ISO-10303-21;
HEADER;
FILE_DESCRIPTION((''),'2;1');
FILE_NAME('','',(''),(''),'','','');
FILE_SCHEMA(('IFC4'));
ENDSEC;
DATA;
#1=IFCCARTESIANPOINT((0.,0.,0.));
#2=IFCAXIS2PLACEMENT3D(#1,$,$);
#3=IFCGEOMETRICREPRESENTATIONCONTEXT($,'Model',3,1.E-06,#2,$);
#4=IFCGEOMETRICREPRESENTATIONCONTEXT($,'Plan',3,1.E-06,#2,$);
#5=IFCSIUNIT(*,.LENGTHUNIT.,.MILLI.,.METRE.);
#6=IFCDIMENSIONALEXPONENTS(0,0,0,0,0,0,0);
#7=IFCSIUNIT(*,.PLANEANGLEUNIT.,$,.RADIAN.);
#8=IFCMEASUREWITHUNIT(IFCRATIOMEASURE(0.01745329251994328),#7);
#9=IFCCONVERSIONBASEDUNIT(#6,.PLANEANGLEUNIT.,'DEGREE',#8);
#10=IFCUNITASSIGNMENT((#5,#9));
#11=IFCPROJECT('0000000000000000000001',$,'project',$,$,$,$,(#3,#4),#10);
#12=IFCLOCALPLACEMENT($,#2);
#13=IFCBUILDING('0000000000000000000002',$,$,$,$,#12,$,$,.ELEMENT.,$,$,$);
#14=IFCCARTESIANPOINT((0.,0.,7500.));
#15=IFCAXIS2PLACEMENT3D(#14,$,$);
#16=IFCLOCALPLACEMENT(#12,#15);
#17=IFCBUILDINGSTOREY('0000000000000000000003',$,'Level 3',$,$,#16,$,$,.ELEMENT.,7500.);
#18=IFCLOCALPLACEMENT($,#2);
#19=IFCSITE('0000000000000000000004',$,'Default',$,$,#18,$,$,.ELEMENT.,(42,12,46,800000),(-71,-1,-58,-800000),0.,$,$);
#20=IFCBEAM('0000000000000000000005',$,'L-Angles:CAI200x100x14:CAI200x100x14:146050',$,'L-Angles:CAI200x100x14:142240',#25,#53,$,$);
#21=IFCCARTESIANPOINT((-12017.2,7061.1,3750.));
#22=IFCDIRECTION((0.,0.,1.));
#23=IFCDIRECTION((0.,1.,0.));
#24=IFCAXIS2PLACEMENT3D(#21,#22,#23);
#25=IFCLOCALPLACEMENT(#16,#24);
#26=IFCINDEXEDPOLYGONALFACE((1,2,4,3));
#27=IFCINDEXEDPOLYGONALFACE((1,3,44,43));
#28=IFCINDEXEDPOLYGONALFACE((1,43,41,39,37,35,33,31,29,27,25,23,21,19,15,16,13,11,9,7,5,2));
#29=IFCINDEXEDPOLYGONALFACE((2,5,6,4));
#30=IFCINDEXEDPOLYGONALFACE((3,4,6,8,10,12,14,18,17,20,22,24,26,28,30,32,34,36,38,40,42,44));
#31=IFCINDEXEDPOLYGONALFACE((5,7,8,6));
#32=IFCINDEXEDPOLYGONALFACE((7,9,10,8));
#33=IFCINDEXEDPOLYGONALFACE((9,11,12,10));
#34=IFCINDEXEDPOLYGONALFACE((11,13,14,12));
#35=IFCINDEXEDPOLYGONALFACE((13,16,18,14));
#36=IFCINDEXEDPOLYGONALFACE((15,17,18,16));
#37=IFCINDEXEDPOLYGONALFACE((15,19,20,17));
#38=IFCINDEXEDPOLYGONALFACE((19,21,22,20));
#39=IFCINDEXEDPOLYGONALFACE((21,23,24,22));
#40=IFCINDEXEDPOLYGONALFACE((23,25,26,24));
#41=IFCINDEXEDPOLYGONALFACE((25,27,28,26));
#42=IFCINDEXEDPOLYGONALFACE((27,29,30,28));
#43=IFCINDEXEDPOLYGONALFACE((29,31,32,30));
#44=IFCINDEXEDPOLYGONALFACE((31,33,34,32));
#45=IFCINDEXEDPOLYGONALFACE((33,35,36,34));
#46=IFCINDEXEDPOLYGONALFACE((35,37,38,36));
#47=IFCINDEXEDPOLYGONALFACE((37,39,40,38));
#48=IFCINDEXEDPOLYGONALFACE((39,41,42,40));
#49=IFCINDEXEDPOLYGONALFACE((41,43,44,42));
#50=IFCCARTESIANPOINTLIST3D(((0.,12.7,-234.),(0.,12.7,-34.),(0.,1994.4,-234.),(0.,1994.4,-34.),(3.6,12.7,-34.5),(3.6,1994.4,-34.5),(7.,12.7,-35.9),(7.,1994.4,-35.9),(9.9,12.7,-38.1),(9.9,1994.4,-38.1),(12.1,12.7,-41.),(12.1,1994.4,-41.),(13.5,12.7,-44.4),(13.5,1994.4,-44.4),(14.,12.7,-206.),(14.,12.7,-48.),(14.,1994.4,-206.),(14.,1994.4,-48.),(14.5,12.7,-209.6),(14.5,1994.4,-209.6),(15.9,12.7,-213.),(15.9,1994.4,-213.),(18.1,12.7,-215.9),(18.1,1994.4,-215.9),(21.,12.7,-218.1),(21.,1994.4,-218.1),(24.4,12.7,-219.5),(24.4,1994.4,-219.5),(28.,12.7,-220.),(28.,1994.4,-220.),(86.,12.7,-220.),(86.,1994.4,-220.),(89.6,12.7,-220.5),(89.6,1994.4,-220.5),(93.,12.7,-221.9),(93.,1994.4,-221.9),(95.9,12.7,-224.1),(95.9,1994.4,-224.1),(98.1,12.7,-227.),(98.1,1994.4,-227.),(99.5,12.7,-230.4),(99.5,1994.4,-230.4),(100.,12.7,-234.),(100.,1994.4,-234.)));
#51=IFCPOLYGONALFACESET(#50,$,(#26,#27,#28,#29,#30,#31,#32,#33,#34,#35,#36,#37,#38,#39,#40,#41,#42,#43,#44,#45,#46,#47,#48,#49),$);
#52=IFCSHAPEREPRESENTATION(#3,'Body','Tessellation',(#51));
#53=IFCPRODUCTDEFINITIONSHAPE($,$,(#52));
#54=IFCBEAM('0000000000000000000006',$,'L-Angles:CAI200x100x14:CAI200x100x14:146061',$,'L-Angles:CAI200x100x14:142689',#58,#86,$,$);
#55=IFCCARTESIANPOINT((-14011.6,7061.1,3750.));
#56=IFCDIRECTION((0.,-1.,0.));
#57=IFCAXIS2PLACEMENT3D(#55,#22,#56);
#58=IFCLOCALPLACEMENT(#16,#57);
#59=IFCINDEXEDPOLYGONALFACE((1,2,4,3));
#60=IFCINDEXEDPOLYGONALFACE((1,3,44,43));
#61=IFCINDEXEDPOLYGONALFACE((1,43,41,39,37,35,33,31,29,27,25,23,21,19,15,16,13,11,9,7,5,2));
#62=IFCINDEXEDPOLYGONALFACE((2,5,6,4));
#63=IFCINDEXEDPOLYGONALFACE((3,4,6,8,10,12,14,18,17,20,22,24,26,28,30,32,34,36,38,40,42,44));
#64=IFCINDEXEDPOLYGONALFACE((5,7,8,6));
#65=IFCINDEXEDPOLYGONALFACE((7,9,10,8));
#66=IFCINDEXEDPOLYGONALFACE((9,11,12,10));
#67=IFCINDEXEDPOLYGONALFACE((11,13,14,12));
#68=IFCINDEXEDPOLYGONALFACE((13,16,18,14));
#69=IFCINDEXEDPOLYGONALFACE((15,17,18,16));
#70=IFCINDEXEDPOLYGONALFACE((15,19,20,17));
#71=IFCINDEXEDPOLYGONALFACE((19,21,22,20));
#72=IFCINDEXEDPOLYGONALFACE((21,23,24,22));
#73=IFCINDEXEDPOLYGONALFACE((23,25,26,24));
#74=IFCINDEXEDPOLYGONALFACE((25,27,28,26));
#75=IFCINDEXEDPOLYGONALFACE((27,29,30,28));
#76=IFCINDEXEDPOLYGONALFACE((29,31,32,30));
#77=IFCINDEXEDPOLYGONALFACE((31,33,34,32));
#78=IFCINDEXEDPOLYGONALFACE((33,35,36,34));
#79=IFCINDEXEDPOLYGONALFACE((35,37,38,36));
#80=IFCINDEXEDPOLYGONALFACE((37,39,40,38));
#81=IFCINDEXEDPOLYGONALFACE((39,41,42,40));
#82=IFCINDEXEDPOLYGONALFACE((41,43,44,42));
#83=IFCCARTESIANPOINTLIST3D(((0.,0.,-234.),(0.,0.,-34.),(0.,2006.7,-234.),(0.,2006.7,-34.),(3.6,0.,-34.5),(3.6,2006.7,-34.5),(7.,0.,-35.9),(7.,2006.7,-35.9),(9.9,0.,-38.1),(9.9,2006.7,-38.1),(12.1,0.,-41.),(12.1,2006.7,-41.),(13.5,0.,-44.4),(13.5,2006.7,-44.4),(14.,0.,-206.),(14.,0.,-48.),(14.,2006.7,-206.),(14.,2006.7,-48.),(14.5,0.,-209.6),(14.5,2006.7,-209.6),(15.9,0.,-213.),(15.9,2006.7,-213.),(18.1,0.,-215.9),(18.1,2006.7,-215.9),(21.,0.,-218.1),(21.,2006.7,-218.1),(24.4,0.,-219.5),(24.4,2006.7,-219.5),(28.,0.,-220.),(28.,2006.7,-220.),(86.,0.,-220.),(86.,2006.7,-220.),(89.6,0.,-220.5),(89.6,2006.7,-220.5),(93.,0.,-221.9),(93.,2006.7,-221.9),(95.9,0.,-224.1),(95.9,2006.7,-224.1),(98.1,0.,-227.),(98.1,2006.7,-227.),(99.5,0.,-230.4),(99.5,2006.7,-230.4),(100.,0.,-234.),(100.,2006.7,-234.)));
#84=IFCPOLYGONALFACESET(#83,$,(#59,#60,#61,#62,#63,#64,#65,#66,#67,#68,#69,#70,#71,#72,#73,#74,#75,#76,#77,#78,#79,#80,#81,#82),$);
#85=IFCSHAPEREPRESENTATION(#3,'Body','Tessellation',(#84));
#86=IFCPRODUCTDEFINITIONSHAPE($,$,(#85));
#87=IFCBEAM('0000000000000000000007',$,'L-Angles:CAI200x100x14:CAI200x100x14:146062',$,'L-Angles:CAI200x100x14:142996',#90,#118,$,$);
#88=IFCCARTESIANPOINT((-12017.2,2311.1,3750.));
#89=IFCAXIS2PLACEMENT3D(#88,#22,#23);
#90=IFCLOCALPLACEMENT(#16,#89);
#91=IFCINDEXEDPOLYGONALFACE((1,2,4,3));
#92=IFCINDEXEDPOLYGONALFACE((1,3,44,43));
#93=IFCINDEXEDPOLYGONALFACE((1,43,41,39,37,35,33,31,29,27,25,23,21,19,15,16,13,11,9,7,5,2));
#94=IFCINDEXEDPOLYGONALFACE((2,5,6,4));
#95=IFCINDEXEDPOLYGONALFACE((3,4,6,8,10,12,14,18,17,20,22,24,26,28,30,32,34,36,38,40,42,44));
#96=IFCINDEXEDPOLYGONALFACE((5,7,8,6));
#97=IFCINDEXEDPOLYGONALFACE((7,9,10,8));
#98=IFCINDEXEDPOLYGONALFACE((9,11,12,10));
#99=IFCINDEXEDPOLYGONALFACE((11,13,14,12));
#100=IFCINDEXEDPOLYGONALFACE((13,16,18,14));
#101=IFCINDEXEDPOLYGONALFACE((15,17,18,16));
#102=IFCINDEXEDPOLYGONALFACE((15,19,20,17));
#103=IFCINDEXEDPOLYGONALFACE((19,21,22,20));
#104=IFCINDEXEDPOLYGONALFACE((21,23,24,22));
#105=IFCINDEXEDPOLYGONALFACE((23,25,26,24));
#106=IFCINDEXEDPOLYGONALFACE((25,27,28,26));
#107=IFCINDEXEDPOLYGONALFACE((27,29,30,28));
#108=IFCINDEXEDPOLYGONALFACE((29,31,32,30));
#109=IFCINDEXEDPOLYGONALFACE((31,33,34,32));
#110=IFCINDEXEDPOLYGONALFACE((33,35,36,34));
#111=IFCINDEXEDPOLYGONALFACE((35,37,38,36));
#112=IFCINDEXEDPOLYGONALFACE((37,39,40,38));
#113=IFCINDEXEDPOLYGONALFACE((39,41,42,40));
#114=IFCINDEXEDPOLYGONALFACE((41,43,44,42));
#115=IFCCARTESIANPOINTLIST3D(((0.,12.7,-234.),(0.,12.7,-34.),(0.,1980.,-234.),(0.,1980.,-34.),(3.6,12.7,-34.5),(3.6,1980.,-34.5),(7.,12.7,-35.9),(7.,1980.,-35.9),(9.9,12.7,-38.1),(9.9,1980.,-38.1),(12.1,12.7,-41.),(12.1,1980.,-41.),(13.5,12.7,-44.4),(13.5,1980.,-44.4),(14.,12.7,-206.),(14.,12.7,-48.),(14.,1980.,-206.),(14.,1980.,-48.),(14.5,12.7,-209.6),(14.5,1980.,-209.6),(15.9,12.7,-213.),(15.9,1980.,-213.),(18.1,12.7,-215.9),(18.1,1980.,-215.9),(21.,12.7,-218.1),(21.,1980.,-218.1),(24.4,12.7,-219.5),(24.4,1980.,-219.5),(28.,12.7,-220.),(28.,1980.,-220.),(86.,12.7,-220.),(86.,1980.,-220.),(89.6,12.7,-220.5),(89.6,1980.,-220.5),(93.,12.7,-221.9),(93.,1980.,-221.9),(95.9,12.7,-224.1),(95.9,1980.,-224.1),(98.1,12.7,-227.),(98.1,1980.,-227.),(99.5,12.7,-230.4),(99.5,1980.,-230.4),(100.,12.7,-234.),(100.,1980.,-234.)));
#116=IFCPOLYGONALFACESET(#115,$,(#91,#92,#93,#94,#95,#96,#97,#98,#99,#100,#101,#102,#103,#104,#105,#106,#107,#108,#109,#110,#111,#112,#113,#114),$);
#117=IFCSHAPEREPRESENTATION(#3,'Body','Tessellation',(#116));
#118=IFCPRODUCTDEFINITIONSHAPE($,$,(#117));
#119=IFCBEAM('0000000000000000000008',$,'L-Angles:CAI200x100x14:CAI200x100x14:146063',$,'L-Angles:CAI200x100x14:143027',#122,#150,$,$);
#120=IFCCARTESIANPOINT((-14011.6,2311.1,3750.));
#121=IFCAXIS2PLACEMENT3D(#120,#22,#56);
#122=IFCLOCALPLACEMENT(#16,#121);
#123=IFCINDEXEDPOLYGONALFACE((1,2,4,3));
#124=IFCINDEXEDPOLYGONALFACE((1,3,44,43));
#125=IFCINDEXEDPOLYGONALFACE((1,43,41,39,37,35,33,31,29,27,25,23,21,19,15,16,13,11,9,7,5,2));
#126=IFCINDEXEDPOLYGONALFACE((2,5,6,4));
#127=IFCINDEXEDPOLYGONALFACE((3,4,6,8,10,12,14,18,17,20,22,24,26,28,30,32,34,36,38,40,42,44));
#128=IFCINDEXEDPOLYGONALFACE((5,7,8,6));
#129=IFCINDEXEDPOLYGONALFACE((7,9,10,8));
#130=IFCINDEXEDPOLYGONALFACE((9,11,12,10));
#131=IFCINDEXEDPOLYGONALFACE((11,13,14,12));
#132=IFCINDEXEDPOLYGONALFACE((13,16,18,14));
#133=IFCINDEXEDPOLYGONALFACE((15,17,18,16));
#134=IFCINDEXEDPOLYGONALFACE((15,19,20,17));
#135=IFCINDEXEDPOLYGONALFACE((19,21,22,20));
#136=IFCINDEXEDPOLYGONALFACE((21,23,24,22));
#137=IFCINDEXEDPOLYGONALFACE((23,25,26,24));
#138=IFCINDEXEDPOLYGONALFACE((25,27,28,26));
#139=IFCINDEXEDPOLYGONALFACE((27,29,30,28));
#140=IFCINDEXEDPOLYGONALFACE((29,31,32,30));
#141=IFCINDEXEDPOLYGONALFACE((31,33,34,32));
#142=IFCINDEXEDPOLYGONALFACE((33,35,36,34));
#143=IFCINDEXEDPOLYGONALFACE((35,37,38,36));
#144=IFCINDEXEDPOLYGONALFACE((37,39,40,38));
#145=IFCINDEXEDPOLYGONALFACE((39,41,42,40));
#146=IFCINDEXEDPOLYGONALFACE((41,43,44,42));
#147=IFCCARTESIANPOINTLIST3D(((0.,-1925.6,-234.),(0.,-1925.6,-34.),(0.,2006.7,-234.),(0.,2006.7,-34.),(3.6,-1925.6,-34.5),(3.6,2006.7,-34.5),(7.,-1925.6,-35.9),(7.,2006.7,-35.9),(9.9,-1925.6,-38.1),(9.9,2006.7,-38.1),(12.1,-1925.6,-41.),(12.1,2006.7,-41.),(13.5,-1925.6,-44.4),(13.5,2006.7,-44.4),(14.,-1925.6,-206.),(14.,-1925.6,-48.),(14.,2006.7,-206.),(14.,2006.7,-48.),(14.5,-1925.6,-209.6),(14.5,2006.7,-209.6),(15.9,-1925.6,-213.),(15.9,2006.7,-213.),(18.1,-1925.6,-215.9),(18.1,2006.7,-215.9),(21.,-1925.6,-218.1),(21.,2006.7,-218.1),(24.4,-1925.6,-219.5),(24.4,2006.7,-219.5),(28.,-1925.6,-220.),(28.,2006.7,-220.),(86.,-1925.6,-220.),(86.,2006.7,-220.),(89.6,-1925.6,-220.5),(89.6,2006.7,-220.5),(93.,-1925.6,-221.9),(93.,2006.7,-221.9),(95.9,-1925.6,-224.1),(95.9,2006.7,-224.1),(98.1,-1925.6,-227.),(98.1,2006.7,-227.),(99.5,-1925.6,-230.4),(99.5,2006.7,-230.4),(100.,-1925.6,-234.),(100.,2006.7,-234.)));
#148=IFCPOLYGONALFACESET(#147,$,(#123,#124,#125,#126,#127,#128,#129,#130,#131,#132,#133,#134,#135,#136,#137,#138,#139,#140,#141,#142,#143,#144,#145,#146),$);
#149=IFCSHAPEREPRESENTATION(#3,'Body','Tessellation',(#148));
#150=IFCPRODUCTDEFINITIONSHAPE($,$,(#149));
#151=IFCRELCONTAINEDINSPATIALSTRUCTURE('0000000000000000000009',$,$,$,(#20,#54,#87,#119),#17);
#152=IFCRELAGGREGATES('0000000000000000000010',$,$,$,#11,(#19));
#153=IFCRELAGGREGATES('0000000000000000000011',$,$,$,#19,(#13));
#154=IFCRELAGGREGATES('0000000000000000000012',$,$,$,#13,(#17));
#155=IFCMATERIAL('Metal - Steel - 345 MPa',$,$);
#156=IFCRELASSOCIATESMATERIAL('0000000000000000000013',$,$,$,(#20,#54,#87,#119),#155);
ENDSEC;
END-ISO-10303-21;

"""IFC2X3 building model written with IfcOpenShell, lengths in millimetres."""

from ifc_helpers import new_model, entity, si_unit, converted_unit, frame, frame_2d, origin, place, context, project, spatial, polyline, circle_curve, parameter, trimmed, segment, composite_curve, outline, extrude, material, element, save


model = new_model("IFC2X3")

# Units and contexts
model_context = context("Model", 3, precision=1e-06, world=origin())
plan_context = context("Plan", 3, precision=1e-06, world=origin())
ifc_project = project(units=[si_unit("LENGTHUNIT", "METRE", prefix="MILLI"), converted_unit("PLANEANGLEUNIT", "DEGREE", entity("IfcRatioMeasure", 0.01745329251994328), si_unit("PLANEANGLEUNIT", "RADIAN"), dimensions=[0, 0, 0, 0, 0, 0, 0])], contexts=[model_context, plan_context])

# Site, building, storey
site_placement = place(None, origin())
site = spatial("IfcSite", under=ifc_project, at=site_placement, Name="Default", CompositionType="ELEMENT", RefLatitude=(42, 12, 46, 800000), RefLongitude=(-71, -1, -58, -800000), RefElevation=0.0)
building_placement = place(None, origin())
building = spatial("IfcBuilding", under=site, at=building_placement, CompositionType="ELEMENT")
storey_placement = place(building_placement, frame((0.0, 0.0, 7500.0)))
storey = spatial("IfcBuildingStorey", under=building, at=storey_placement, Name="Level 3", CompositionType="ELEMENT", Elevation=7500.0)

# Shared definitions
ifc_material_1 = material(Name="Metal - Steel - 345 MPa")

# Beams
beam_1_placement = place(storey_placement, frame((-12017.2, 7061.1, 3750.0), z_axis=(0.0, 0.0, 1.0), x_axis=(0.0, 1.0, 0.0)))
element("IfcBeam", 1, at=beam_1_placement, inside=storey, material=ifc_material_1, Name="L-Angles:CAI200x100x14:CAI200x100x14:146050", ObjectType="L-Angles:CAI200x100x14:142240", context=model_context, shape_type="SweptSolid", body=[
    extrude(outline(composite_curve([segment(polyline([(-34.6, -63.1), (65.4, -63.1)]), True, "CONTINUOUS"), segment(trimmed(circle_curve(frame_2d((51.4, -63.1), x_axis=(1.0, 0.0)), 14.0), [parameter(0.0)], [parameter(90.0)], True, "PARAMETER"), True, "CONTINUOUS"), segment(polyline([(51.4, -49.1), (-6.6, -49.1)]), True, "CONTINUOUS"), segment(trimmed(circle_curve(frame_2d((-6.6, -35.1), x_axis=(1.0, 0.0)), 14.0), [parameter(180.0)], [parameter(270.0)], True, "PARAMETER"), False, "CONTINUOUS"), segment(polyline([(-20.6, -35.1), (-20.6, 122.9)]), True, "CONTINUOUS"), segment(trimmed(circle_curve(frame_2d((-34.6, 122.9), x_axis=(1.0, 0.0)), 14.0), [parameter(0.0)], [parameter(90.0)], True, "PARAMETER"), True, "CONTINUOUS"), segment(polyline([(-34.6, 136.9), (-34.6, -63.1)]), True, "CONTINUOUS")], self_intersect=False)), frame((34.6, 1994.4, -170.9), z_axis=(0.0, -1.0, 0.0), x_axis=(1.0, 0.0, 0.0)), (0.0, 0.0, 1.0), 1981.7),
])
beam_2_placement = place(storey_placement, frame((-14011.6, 7061.1, 3750.0), z_axis=(0.0, 0.0, 1.0), x_axis=(0.0, -1.0, 0.0)))
element("IfcBeam", 2, at=beam_2_placement, inside=storey, material=ifc_material_1, Name="L-Angles:CAI200x100x14:CAI200x100x14:146061", ObjectType="L-Angles:CAI200x100x14:142689", context=model_context, shape_type="SweptSolid", body=[
    extrude(outline(composite_curve([segment(polyline([(-63.1, -34.6), (136.9, -34.6)]), True, "CONTINUOUS"), segment(trimmed(circle_curve(frame_2d((122.9, -34.6), x_axis=(0.0, 1.0)), 14.0), [parameter(270.0)], [parameter(0.0)], True, "PARAMETER"), True, "CONTINUOUS"), segment(polyline([(122.9, -20.6), (-35.1, -20.6)]), True, "CONTINUOUS"), segment(trimmed(circle_curve(frame_2d((-35.1, -6.6), x_axis=(0.0, 1.0)), 14.0), [parameter(90.0)], [parameter(180.0)], True, "PARAMETER"), False, "CONTINUOUS"), segment(polyline([(-49.1, -6.6), (-49.1, 51.4)]), True, "CONTINUOUS"), segment(trimmed(circle_curve(frame_2d((-63.1, 51.4), x_axis=(0.0, 1.0)), 14.0), [parameter(270.0)], [parameter(360.0)], True, "PARAMETER"), True, "CONTINUOUS"), segment(polyline([(-63.1, 65.4), (-63.1, -34.6)]), True, "CONTINUOUS")], self_intersect=False)), frame((34.6, 0.0, -170.9), z_axis=(0.0, 1.0, 0.0), x_axis=(0.0, 0.0, 1.0)), (0.0, 0.0, 1.0), 2006.7),
])
beam_3_placement = place(storey_placement, frame((-12017.2, 2311.1, 3750.0), z_axis=(0.0, 0.0, 1.0), x_axis=(0.0, 1.0, 0.0)))
element("IfcBeam", 3, at=beam_3_placement, inside=storey, material=ifc_material_1, Name="L-Angles:CAI200x100x14:CAI200x100x14:146062", ObjectType="L-Angles:CAI200x100x14:142996", context=model_context, shape_type="SweptSolid", body=[
    extrude(outline(composite_curve([segment(polyline([(-34.6, -63.1), (65.4, -63.1)]), True, "CONTINUOUS"), segment(trimmed(circle_curve(frame_2d((51.4, -63.1), x_axis=(0.0, 1.0)), 14.0), [parameter(270.0)], [parameter(360.0)], True, "PARAMETER"), True, "CONTINUOUS"), segment(polyline([(51.4, -49.1), (-6.6, -49.1)]), True, "CONTINUOUS"), segment(trimmed(circle_curve(frame_2d((-6.6, -35.1), x_axis=(-1.0, 0.0)), 14.0), [parameter(0.0)], [parameter(90.0)], True, "PARAMETER"), False, "CONTINUOUS"), segment(polyline([(-20.6, -35.1), (-20.6, 122.9)]), True, "CONTINUOUS"), segment(trimmed(circle_curve(frame_2d((-34.6, 122.9), x_axis=(0.0, 1.0)), 14.0), [parameter(270.0)], [parameter(0.0)], True, "PARAMETER"), True, "CONTINUOUS"), segment(polyline([(-34.6, 136.9), (-34.6, -63.1)]), True, "CONTINUOUS")], self_intersect=False)), frame((34.6, 1980.0, -170.9), z_axis=(0.0, -1.0, 0.0), x_axis=(1.0, 0.0, 0.0)), (0.0, 0.0, 1.0), 1967.3),
])
beam_4_placement = place(storey_placement, frame((-14011.6, 2311.1, 3750.0), z_axis=(0.0, 0.0, 1.0), x_axis=(0.0, -1.0, 0.0)))
element("IfcBeam", 4, at=beam_4_placement, inside=storey, material=ifc_material_1, Name="L-Angles:CAI200x100x14:CAI200x100x14:146063", ObjectType="L-Angles:CAI200x100x14:143027", context=model_context, shape_type="SweptSolid", body=[
    extrude(outline(composite_curve([segment(polyline([(-63.1, -34.6), (136.9, -34.6)]), True, "CONTINUOUS"), segment(trimmed(circle_curve(frame_2d((122.9, -34.6), x_axis=(1.0, 0.0)), 14.0), [parameter(360.0)], [parameter(90.0)], True, "PARAMETER"), True, "CONTINUOUS"), segment(polyline([(122.9, -20.6), (-35.1, -20.6)]), True, "CONTINUOUS"), segment(trimmed(circle_curve(frame_2d((-35.1, -6.6), x_axis=(0.0, -1.0)), 14.0), [parameter(270.0)], [parameter(360.0)], True, "PARAMETER"), False, "CONTINUOUS"), segment(polyline([(-49.1, -6.6), (-49.1, 51.4)]), True, "CONTINUOUS"), segment(trimmed(circle_curve(frame_2d((-63.1, 51.4), x_axis=(1.0, 0.0)), 14.0), [parameter(0.0)], [parameter(90.0)], True, "PARAMETER"), True, "CONTINUOUS"), segment(polyline([(-63.1, 65.4), (-63.1, -34.6)]), True, "CONTINUOUS")], self_intersect=False)), frame((34.6, -1925.6, -170.9), z_axis=(0.0, 1.0, 0.0), x_axis=(0.0, 0.0, 1.0)), (0.0, 0.0, 1.0), 3932.3),
])

save(model, "model.ifc")
